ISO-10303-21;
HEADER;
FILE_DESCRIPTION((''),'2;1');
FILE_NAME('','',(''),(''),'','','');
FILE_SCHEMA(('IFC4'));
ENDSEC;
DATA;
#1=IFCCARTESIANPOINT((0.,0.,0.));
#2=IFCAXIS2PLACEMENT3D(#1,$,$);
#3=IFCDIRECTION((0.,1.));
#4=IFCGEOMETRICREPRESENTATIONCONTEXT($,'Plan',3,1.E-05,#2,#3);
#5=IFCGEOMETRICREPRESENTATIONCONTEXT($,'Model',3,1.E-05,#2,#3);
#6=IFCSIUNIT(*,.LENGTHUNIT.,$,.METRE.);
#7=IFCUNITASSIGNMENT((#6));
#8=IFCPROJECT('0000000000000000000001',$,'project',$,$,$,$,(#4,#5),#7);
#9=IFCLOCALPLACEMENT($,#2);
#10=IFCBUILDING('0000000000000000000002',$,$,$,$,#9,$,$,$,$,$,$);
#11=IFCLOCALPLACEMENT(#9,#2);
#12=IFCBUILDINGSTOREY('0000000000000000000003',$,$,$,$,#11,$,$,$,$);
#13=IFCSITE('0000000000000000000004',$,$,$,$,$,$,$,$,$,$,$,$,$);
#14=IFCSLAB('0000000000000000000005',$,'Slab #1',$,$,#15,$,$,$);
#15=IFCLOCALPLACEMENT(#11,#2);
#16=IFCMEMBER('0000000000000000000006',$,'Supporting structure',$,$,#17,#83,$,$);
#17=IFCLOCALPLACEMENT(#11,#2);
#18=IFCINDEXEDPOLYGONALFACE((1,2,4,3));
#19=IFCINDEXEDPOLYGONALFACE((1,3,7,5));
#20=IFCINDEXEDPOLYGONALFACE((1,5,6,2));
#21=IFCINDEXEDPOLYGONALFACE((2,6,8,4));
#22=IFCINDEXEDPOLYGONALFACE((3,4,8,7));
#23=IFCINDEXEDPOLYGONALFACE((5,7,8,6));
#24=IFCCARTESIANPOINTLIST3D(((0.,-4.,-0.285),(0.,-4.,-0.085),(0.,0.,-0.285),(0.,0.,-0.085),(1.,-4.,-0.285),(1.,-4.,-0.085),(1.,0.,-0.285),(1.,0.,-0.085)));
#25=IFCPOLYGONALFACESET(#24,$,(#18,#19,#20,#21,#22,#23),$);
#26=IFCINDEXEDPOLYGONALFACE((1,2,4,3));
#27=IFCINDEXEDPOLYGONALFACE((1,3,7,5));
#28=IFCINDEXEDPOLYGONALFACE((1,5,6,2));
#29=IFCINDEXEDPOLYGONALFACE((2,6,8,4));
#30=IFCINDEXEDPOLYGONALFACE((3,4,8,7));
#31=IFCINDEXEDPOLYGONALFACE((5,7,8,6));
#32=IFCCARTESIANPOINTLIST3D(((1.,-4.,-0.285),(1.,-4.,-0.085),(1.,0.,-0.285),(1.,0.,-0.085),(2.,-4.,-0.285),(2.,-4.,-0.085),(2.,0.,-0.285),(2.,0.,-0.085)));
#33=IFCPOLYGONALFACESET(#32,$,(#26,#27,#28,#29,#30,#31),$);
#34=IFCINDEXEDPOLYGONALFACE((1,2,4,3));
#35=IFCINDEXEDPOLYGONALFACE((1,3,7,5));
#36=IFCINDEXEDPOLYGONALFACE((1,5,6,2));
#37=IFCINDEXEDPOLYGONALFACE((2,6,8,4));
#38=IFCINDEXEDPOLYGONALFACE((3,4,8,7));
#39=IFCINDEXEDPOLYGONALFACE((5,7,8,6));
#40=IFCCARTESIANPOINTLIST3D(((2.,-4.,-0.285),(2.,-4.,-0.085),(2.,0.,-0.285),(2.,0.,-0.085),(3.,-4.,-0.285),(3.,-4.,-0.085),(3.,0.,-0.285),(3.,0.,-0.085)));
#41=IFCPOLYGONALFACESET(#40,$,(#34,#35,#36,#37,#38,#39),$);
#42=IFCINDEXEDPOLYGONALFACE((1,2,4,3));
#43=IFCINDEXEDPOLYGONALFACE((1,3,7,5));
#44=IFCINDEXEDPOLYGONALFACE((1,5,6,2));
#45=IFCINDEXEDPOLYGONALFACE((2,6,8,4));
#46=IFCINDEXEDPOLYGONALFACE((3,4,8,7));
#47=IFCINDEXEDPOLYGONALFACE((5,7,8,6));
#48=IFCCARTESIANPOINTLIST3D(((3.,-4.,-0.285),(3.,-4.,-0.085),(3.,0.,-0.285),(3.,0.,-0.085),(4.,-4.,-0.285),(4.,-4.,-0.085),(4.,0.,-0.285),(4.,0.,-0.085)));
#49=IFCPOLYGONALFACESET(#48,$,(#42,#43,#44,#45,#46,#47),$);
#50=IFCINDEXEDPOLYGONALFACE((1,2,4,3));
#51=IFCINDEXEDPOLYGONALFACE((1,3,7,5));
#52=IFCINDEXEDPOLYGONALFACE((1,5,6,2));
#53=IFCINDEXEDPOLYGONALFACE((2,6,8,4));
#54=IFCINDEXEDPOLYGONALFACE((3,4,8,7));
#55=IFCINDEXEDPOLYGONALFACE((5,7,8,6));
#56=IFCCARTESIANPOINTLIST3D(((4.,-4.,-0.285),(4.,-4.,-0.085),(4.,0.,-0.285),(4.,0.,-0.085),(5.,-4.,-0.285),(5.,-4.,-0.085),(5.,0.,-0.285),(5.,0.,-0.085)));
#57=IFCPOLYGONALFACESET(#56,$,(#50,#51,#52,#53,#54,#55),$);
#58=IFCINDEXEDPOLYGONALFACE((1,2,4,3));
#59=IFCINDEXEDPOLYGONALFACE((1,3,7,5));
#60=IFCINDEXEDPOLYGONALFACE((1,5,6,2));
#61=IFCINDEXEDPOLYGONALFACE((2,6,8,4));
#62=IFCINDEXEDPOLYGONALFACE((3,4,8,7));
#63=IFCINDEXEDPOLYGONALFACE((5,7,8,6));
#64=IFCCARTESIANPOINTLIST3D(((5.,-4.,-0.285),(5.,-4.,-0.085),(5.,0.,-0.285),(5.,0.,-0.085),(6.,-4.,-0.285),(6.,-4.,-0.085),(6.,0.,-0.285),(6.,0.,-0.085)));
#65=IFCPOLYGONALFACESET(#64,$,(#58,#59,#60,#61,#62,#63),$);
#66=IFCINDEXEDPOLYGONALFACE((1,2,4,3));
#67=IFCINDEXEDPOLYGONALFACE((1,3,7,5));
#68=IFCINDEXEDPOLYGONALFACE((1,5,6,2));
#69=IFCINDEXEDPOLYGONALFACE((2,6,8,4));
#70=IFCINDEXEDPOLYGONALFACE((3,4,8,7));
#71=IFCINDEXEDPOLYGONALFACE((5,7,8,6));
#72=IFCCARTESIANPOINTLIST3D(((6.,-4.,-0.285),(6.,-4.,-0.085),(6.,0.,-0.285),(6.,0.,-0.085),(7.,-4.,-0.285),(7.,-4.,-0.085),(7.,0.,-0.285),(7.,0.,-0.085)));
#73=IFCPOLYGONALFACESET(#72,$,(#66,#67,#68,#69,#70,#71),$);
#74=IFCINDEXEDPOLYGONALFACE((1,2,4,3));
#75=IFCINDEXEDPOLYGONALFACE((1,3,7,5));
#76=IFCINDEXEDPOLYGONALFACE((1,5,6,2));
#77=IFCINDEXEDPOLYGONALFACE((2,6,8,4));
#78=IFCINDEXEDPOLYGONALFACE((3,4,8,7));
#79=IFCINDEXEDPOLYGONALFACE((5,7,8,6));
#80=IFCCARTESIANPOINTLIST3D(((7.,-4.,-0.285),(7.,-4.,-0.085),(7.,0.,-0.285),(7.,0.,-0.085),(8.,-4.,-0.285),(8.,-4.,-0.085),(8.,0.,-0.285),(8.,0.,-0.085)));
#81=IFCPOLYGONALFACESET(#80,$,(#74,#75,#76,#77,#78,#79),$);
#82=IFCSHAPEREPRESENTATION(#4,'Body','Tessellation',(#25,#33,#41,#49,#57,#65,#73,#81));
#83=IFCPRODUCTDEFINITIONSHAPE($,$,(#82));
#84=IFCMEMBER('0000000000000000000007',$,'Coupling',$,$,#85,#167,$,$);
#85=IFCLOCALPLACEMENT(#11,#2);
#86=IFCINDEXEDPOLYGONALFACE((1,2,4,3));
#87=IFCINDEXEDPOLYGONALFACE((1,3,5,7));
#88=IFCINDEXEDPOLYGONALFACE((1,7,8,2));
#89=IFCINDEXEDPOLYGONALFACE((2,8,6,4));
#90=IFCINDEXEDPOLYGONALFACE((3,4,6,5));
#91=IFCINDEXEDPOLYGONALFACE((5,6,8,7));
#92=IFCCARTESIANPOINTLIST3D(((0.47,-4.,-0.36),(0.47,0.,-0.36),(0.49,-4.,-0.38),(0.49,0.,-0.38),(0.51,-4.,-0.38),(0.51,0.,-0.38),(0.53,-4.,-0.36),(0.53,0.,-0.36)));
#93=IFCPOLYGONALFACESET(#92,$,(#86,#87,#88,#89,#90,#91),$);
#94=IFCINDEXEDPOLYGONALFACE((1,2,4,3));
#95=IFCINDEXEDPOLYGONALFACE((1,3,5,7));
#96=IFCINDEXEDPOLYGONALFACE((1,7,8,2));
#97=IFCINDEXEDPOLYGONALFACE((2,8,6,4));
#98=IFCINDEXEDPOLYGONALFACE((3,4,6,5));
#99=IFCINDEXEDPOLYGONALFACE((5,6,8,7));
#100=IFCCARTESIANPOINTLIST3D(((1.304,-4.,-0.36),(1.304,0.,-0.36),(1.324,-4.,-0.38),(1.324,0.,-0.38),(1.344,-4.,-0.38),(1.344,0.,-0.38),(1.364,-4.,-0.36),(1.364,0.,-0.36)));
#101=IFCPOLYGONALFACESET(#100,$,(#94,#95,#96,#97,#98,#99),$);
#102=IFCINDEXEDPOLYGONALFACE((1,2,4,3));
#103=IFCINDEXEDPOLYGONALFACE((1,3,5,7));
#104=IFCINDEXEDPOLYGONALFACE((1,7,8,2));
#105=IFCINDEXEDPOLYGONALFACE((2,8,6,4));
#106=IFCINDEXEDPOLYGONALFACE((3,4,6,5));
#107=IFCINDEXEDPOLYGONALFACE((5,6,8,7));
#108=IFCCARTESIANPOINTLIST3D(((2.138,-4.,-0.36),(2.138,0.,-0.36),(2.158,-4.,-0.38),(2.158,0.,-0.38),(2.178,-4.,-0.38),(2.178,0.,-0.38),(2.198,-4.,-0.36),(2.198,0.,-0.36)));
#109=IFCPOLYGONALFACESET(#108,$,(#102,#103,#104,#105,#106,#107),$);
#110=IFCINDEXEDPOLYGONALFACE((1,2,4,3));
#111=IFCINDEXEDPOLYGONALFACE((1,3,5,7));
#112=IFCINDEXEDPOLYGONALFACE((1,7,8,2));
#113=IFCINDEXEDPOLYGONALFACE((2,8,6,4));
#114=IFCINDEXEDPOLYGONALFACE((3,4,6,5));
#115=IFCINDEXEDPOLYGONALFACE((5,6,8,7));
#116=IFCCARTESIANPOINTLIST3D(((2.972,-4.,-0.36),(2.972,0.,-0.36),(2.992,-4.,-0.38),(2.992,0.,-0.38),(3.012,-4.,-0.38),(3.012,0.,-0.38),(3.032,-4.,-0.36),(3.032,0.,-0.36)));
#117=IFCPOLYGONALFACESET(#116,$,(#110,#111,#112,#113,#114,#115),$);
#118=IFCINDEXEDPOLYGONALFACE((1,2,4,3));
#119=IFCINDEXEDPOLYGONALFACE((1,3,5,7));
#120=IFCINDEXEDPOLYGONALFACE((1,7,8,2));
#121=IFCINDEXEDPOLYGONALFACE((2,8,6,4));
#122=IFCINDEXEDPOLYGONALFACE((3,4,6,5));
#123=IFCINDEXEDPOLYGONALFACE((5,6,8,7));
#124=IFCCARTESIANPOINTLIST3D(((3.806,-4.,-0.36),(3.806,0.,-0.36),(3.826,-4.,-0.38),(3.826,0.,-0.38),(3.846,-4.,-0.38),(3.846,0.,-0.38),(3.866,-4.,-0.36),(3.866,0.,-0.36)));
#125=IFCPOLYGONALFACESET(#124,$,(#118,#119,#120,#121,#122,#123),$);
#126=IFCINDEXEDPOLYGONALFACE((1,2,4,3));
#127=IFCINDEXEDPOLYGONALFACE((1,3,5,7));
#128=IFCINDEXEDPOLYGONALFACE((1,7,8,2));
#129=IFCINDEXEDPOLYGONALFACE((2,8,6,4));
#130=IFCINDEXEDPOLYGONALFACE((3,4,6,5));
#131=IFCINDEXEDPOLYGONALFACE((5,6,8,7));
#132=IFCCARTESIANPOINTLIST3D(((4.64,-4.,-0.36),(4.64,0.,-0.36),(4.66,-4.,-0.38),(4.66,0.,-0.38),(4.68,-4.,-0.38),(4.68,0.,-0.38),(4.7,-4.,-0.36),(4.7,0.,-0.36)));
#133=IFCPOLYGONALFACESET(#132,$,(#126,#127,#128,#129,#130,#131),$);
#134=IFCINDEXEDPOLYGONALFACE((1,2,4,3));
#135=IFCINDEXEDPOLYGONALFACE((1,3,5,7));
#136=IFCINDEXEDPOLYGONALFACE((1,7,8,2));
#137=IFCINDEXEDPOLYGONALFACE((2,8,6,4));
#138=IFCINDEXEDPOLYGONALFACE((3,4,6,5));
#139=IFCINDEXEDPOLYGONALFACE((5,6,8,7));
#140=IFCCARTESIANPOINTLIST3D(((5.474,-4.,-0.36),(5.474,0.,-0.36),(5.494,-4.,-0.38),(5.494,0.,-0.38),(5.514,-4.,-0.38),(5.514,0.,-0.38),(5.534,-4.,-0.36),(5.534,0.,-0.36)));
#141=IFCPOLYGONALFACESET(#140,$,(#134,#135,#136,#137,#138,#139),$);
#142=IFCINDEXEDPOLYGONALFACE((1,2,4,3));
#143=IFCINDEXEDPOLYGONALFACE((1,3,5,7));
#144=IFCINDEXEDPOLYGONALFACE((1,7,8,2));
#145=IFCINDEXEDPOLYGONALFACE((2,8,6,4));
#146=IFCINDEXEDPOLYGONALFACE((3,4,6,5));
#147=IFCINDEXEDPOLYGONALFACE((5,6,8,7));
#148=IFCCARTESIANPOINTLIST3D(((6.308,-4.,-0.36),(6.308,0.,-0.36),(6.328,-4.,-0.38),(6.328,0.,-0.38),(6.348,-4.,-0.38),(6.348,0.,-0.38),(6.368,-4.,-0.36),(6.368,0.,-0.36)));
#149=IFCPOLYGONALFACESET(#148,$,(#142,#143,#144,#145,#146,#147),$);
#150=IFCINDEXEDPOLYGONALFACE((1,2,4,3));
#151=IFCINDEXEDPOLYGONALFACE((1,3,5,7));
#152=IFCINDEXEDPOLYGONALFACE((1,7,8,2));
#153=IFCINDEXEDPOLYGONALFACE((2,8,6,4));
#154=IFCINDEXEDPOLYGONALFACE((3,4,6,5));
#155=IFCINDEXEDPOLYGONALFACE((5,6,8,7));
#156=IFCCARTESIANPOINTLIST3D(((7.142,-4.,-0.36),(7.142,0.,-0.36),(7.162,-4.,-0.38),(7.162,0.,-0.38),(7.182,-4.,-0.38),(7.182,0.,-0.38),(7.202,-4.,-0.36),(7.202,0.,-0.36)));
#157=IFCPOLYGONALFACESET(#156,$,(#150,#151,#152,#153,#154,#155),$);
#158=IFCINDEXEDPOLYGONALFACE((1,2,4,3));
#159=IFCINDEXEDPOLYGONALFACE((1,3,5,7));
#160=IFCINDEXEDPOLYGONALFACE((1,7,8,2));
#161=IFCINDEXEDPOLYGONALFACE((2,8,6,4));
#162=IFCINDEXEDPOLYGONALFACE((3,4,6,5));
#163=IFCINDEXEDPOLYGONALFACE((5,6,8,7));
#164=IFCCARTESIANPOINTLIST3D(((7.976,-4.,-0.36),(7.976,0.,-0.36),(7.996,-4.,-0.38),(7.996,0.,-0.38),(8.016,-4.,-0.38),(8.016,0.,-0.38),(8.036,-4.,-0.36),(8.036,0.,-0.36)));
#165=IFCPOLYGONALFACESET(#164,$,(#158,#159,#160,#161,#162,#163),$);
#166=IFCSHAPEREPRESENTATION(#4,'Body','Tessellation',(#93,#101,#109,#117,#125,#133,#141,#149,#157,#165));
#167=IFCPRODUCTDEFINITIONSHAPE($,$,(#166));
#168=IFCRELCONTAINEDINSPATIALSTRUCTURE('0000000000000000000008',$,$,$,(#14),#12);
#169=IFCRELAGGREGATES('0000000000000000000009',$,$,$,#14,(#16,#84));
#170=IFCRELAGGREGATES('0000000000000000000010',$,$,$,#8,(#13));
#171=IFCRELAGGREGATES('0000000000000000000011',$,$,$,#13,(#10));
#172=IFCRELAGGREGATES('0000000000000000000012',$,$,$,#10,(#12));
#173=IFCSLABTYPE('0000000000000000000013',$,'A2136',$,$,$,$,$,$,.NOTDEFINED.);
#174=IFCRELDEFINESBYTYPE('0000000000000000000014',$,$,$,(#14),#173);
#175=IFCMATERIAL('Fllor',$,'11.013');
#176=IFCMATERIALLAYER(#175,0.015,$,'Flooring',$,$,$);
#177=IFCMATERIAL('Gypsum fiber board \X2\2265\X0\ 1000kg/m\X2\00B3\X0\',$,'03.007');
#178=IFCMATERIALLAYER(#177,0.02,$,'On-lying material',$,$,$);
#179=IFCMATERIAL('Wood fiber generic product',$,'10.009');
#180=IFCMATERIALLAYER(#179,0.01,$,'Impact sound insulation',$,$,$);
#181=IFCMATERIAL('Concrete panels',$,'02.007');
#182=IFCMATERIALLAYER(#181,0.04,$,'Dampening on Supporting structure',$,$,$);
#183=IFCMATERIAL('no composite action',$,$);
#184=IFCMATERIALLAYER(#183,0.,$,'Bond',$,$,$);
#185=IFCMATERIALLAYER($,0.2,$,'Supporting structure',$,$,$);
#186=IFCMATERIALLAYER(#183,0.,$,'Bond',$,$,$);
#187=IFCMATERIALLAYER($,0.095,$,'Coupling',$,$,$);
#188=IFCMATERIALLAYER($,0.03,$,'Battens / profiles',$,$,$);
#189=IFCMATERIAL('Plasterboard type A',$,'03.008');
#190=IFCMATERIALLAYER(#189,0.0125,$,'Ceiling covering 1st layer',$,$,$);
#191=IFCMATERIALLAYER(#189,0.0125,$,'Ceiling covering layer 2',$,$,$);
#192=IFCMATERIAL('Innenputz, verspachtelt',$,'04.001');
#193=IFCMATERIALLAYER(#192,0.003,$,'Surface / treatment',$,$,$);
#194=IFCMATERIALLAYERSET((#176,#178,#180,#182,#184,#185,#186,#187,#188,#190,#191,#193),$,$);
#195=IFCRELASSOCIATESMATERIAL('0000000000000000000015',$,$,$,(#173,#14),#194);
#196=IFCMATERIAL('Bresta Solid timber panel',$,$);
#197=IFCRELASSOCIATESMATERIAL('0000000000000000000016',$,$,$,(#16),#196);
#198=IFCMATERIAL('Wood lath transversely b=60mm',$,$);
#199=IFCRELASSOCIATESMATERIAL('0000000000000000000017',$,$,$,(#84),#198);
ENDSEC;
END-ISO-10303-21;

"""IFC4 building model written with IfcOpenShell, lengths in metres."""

from ifc_helpers import new_model, si_unit, direction, frame, frame_2d, origin, place, context, project, spatial, polyline, rectangle, outline, extrude, material, layer, layer_set, type_object, element, aggregate, save


model = new_model("IFC4")

# Units and contexts
plan_context = context("Plan", 3, precision=1e-05, world=origin(), true_north=direction((0.0, 1.0)))
model_context = context("Model", 3, precision=1e-05, world=origin(), true_north=direction((0.0, 1.0)))
ifc_project = project(units=[si_unit("LENGTHUNIT", "METRE")], contexts=[plan_context, model_context])

# Site, building, storey
site = spatial("IfcSite", under=ifc_project)
building_placement = place(None, origin())
building = spatial("IfcBuilding", under=site, at=building_placement)
storey_placement = place(building_placement, origin())
storey = spatial("IfcBuildingStorey", under=building, at=storey_placement)

# Slab, members
ifc_material_1 = material(Name="Fllor", Category="11.013")
ifc_layer_1 = layer(ifc_material_1, 0.015, Name="Flooring")
ifc_material_2 = material(Name="Gypsum fiber board ≥ 1000kg/m³", Category="03.007")
ifc_layer_2 = layer(ifc_material_2, 0.02, Name="On-lying material")
ifc_material_3 = material(Name="Wood fiber generic product", Category="10.009")
ifc_layer_3 = layer(ifc_material_3, 0.01, Name="Impact sound insulation")
ifc_material_4 = material(Name="Concrete panels", Category="02.007")
ifc_layer_4 = layer(ifc_material_4, 0.04, Name="Dampening on Supporting structure")
ifc_material_5 = material(Name="no composite action")
ifc_layer_5 = layer(ifc_material_5, 0.0, Name="Bond")
ifc_layer_6 = layer(None, 0.2, Name="Supporting structure")
ifc_layer_7 = layer(ifc_material_5, 0.0, Name="Bond")
ifc_layer_8 = layer(None, 0.095, Name="Coupling")
ifc_layer_9 = layer(None, 0.03, Name="Battens / profiles")
ifc_material_6 = material(Name="Plasterboard type A", Category="03.008")
ifc_layer_10 = layer(ifc_material_6, 0.0125, Name="Ceiling covering 1st layer")
ifc_layer_11 = layer(ifc_material_6, 0.0125, Name="Ceiling covering layer 2")
ifc_material_7 = material(Name="Innenputz, verspachtelt", Category="04.001")
ifc_layer_12 = layer(ifc_material_7, 0.003, Name="Surface / treatment")
ifc_layer_set = layer_set([ifc_layer_1, ifc_layer_2, ifc_layer_3, ifc_layer_4, ifc_layer_5, ifc_layer_6, ifc_layer_7, ifc_layer_8, ifc_layer_9, ifc_layer_10, ifc_layer_11, ifc_layer_12])
slab_type = type_object("IfcSlabType", Name="A2136", PredefinedType="NOTDEFINED", material=ifc_layer_set)
slab_placement = place(None, frame((0.0, 0.0, 0.0), z_axis=(0.0, 0.0, -1.0), x_axis=(1.0, 0.0, 0.0)))
slab = element("IfcSlab", 1, at=slab_placement, inside=storey, type_object=slab_type, material=ifc_layer_set, Name="Slab #1")
ifc_material_8 = material(Name="Bresta Solid timber panel")
member_1_placement = place(slab_placement, origin())
member_1 = element("IfcMember", 2, at=member_1_placement, material=ifc_material_8, Name="Supporting structure", context=plan_context, shape_type="SweptSolid", body=[
    extrude(rectangle(XDim=1.0, YDim=0.2, at=frame_2d((0.5, 0.1), x_axis=(1.0, 0.0))), frame((0.0, 4.0, 0.085), z_axis=(0.0, -1.0, 0.0), x_axis=(1.0, 0.0, 0.0)), (0.0, 0.0, 1.0), 4.0),
    extrude(rectangle(XDim=1.0, YDim=0.2, at=frame_2d((0.5, 0.1), x_axis=(1.0, 0.0))), frame((1.0, 4.0, 0.085), z_axis=(0.0, -1.0, 0.0), x_axis=(1.0, 0.0, 0.0)), (0.0, 0.0, 1.0), 4.0),
    extrude(rectangle(XDim=1.0, YDim=0.2, at=frame_2d((0.5, 0.1), x_axis=(1.0, 0.0))), frame((2.0, 4.0, 0.085), z_axis=(0.0, -1.0, 0.0), x_axis=(1.0, 0.0, 0.0)), (0.0, 0.0, 1.0), 4.0),
    extrude(rectangle(XDim=1.0, YDim=0.2, at=frame_2d((0.5, 0.1), x_axis=(1.0, 0.0))), frame((3.0, 4.0, 0.085), z_axis=(0.0, -1.0, 0.0), x_axis=(1.0, 0.0, 0.0)), (0.0, 0.0, 1.0), 4.0),
    extrude(rectangle(XDim=1.0, YDim=0.2, at=frame_2d((0.5, 0.1), x_axis=(1.0, 0.0))), frame((4.0, 4.0, 0.085), z_axis=(0.0, -1.0, 0.0), x_axis=(1.0, 0.0, 0.0)), (0.0, 0.0, 1.0), 4.0),
    extrude(rectangle(XDim=1.0, YDim=0.2, at=frame_2d((0.5, 0.1), x_axis=(1.0, 0.0))), frame((5.0, 4.0, 0.085), z_axis=(0.0, -1.0, 0.0), x_axis=(1.0, 0.0, 0.0)), (0.0, 0.0, 1.0), 4.0),
    extrude(rectangle(XDim=1.0, YDim=0.2, at=frame_2d((0.5, 0.1), x_axis=(1.0, 0.0))), frame((6.0, 4.0, 0.085), z_axis=(0.0, -1.0, 0.0), x_axis=(1.0, 0.0, 0.0)), (0.0, 0.0, 1.0), 4.0),
    extrude(rectangle(XDim=1.0, YDim=0.2, at=frame_2d((0.5, 0.1), x_axis=(1.0, 0.0))), frame((7.0, 4.0, 0.085), z_axis=(0.0, -1.0, 0.0), x_axis=(1.0, 0.0, 0.0)), (0.0, 0.0, 1.0), 4.0),
])
ifc_material_9 = material(Name="Wood lath transversely b=60mm")
member_2_placement = place(slab_placement, origin())
member_2 = element("IfcMember", 3, at=member_2_placement, material=ifc_material_9, Name="Coupling", context=plan_context, shape_type="SweptSolid", body=[
    extrude(outline(polyline([(0.0, 0.0), (0.06, 0.0), (0.04, 0.02), (0.02, 0.02), (0.0, 0.0)])), frame((0.47, 4.0, 0.36), z_axis=(0.0, -1.0, 0.0), x_axis=(1.0, 0.0, 0.0)), (0.0, 0.0, 1.0), 4.0),
    extrude(outline(polyline([(0.0, 0.0), (0.06, 0.0), (0.04, 0.02), (0.02, 0.02), (0.0, 0.0)])), frame((1.304, 4.0, 0.36), z_axis=(0.0, -1.0, 0.0), x_axis=(1.0, 0.0, 0.0)), (0.0, 0.0, 1.0), 4.0),
    extrude(outline(polyline([(0.0, 0.0), (0.06, 0.0), (0.04, 0.02), (0.02, 0.02), (0.0, 0.0)])), frame((2.138, 4.0, 0.36), z_axis=(0.0, -1.0, 0.0), x_axis=(1.0, 0.0, 0.0)), (0.0, 0.0, 1.0), 4.0),
    extrude(outline(polyline([(0.0, 0.0), (0.06, 0.0), (0.04, 0.02), (0.02, 0.02), (0.0, 0.0)])), frame((2.972, 4.0, 0.36), z_axis=(0.0, -1.0, 0.0), x_axis=(1.0, 0.0, 0.0)), (0.0, 0.0, 1.0), 4.0),
    extrude(outline(polyline([(0.0, 0.0), (0.06, 0.0), (0.04, 0.02), (0.02, 0.02), (0.0, 0.0)])), frame((3.806, 4.0, 0.36), z_axis=(0.0, -1.0, 0.0), x_axis=(1.0, 0.0, 0.0)), (0.0, 0.0, 1.0), 4.0),
    extrude(outline(polyline([(0.0, 0.0), (0.06, 0.0), (0.04, 0.02), (0.02, 0.02), (0.0, 0.0)])), frame((4.64, 4.0, 0.36), z_axis=(0.0, -1.0, 0.0), x_axis=(1.0, 0.0, 0.0)), (0.0, 0.0, 1.0), 4.0),
    extrude(outline(polyline([(0.0, 0.0), (0.06, 0.0), (0.04, 0.02), (0.02, 0.02), (0.0, 0.0)])), frame((5.474, 4.0, 0.36), z_axis=(0.0, -1.0, 0.0), x_axis=(1.0, 0.0, 0.0)), (0.0, 0.0, 1.0), 4.0),
    extrude(outline(polyline([(0.0, 0.0), (0.06, 0.0), (0.04, 0.02), (0.02, 0.02), (0.0, 0.0)])), frame((6.308, 4.0, 0.36), z_axis=(0.0, -1.0, 0.0), x_axis=(1.0, 0.0, 0.0)), (0.0, 0.0, 1.0), 4.0),
    extrude(outline(polyline([(0.0, 0.0), (0.06, 0.0), (0.04, 0.02), (0.02, 0.02), (0.0, 0.0)])), frame((7.142, 4.0, 0.36), z_axis=(0.0, -1.0, 0.0), x_axis=(1.0, 0.0, 0.0)), (0.0, 0.0, 1.0), 4.0),
    extrude(outline(polyline([(0.0, 0.0), (0.06, 0.0), (0.04, 0.02), (0.02, 0.02), (0.0, 0.0)])), frame((7.976, 4.0, 0.36), z_axis=(0.0, -1.0, 0.0), x_axis=(1.0, 0.0, 0.0)), (0.0, 0.0, 1.0), 4.0),
])
aggregate(slab, [member_1, member_2])

save(model, "model.ifc")
